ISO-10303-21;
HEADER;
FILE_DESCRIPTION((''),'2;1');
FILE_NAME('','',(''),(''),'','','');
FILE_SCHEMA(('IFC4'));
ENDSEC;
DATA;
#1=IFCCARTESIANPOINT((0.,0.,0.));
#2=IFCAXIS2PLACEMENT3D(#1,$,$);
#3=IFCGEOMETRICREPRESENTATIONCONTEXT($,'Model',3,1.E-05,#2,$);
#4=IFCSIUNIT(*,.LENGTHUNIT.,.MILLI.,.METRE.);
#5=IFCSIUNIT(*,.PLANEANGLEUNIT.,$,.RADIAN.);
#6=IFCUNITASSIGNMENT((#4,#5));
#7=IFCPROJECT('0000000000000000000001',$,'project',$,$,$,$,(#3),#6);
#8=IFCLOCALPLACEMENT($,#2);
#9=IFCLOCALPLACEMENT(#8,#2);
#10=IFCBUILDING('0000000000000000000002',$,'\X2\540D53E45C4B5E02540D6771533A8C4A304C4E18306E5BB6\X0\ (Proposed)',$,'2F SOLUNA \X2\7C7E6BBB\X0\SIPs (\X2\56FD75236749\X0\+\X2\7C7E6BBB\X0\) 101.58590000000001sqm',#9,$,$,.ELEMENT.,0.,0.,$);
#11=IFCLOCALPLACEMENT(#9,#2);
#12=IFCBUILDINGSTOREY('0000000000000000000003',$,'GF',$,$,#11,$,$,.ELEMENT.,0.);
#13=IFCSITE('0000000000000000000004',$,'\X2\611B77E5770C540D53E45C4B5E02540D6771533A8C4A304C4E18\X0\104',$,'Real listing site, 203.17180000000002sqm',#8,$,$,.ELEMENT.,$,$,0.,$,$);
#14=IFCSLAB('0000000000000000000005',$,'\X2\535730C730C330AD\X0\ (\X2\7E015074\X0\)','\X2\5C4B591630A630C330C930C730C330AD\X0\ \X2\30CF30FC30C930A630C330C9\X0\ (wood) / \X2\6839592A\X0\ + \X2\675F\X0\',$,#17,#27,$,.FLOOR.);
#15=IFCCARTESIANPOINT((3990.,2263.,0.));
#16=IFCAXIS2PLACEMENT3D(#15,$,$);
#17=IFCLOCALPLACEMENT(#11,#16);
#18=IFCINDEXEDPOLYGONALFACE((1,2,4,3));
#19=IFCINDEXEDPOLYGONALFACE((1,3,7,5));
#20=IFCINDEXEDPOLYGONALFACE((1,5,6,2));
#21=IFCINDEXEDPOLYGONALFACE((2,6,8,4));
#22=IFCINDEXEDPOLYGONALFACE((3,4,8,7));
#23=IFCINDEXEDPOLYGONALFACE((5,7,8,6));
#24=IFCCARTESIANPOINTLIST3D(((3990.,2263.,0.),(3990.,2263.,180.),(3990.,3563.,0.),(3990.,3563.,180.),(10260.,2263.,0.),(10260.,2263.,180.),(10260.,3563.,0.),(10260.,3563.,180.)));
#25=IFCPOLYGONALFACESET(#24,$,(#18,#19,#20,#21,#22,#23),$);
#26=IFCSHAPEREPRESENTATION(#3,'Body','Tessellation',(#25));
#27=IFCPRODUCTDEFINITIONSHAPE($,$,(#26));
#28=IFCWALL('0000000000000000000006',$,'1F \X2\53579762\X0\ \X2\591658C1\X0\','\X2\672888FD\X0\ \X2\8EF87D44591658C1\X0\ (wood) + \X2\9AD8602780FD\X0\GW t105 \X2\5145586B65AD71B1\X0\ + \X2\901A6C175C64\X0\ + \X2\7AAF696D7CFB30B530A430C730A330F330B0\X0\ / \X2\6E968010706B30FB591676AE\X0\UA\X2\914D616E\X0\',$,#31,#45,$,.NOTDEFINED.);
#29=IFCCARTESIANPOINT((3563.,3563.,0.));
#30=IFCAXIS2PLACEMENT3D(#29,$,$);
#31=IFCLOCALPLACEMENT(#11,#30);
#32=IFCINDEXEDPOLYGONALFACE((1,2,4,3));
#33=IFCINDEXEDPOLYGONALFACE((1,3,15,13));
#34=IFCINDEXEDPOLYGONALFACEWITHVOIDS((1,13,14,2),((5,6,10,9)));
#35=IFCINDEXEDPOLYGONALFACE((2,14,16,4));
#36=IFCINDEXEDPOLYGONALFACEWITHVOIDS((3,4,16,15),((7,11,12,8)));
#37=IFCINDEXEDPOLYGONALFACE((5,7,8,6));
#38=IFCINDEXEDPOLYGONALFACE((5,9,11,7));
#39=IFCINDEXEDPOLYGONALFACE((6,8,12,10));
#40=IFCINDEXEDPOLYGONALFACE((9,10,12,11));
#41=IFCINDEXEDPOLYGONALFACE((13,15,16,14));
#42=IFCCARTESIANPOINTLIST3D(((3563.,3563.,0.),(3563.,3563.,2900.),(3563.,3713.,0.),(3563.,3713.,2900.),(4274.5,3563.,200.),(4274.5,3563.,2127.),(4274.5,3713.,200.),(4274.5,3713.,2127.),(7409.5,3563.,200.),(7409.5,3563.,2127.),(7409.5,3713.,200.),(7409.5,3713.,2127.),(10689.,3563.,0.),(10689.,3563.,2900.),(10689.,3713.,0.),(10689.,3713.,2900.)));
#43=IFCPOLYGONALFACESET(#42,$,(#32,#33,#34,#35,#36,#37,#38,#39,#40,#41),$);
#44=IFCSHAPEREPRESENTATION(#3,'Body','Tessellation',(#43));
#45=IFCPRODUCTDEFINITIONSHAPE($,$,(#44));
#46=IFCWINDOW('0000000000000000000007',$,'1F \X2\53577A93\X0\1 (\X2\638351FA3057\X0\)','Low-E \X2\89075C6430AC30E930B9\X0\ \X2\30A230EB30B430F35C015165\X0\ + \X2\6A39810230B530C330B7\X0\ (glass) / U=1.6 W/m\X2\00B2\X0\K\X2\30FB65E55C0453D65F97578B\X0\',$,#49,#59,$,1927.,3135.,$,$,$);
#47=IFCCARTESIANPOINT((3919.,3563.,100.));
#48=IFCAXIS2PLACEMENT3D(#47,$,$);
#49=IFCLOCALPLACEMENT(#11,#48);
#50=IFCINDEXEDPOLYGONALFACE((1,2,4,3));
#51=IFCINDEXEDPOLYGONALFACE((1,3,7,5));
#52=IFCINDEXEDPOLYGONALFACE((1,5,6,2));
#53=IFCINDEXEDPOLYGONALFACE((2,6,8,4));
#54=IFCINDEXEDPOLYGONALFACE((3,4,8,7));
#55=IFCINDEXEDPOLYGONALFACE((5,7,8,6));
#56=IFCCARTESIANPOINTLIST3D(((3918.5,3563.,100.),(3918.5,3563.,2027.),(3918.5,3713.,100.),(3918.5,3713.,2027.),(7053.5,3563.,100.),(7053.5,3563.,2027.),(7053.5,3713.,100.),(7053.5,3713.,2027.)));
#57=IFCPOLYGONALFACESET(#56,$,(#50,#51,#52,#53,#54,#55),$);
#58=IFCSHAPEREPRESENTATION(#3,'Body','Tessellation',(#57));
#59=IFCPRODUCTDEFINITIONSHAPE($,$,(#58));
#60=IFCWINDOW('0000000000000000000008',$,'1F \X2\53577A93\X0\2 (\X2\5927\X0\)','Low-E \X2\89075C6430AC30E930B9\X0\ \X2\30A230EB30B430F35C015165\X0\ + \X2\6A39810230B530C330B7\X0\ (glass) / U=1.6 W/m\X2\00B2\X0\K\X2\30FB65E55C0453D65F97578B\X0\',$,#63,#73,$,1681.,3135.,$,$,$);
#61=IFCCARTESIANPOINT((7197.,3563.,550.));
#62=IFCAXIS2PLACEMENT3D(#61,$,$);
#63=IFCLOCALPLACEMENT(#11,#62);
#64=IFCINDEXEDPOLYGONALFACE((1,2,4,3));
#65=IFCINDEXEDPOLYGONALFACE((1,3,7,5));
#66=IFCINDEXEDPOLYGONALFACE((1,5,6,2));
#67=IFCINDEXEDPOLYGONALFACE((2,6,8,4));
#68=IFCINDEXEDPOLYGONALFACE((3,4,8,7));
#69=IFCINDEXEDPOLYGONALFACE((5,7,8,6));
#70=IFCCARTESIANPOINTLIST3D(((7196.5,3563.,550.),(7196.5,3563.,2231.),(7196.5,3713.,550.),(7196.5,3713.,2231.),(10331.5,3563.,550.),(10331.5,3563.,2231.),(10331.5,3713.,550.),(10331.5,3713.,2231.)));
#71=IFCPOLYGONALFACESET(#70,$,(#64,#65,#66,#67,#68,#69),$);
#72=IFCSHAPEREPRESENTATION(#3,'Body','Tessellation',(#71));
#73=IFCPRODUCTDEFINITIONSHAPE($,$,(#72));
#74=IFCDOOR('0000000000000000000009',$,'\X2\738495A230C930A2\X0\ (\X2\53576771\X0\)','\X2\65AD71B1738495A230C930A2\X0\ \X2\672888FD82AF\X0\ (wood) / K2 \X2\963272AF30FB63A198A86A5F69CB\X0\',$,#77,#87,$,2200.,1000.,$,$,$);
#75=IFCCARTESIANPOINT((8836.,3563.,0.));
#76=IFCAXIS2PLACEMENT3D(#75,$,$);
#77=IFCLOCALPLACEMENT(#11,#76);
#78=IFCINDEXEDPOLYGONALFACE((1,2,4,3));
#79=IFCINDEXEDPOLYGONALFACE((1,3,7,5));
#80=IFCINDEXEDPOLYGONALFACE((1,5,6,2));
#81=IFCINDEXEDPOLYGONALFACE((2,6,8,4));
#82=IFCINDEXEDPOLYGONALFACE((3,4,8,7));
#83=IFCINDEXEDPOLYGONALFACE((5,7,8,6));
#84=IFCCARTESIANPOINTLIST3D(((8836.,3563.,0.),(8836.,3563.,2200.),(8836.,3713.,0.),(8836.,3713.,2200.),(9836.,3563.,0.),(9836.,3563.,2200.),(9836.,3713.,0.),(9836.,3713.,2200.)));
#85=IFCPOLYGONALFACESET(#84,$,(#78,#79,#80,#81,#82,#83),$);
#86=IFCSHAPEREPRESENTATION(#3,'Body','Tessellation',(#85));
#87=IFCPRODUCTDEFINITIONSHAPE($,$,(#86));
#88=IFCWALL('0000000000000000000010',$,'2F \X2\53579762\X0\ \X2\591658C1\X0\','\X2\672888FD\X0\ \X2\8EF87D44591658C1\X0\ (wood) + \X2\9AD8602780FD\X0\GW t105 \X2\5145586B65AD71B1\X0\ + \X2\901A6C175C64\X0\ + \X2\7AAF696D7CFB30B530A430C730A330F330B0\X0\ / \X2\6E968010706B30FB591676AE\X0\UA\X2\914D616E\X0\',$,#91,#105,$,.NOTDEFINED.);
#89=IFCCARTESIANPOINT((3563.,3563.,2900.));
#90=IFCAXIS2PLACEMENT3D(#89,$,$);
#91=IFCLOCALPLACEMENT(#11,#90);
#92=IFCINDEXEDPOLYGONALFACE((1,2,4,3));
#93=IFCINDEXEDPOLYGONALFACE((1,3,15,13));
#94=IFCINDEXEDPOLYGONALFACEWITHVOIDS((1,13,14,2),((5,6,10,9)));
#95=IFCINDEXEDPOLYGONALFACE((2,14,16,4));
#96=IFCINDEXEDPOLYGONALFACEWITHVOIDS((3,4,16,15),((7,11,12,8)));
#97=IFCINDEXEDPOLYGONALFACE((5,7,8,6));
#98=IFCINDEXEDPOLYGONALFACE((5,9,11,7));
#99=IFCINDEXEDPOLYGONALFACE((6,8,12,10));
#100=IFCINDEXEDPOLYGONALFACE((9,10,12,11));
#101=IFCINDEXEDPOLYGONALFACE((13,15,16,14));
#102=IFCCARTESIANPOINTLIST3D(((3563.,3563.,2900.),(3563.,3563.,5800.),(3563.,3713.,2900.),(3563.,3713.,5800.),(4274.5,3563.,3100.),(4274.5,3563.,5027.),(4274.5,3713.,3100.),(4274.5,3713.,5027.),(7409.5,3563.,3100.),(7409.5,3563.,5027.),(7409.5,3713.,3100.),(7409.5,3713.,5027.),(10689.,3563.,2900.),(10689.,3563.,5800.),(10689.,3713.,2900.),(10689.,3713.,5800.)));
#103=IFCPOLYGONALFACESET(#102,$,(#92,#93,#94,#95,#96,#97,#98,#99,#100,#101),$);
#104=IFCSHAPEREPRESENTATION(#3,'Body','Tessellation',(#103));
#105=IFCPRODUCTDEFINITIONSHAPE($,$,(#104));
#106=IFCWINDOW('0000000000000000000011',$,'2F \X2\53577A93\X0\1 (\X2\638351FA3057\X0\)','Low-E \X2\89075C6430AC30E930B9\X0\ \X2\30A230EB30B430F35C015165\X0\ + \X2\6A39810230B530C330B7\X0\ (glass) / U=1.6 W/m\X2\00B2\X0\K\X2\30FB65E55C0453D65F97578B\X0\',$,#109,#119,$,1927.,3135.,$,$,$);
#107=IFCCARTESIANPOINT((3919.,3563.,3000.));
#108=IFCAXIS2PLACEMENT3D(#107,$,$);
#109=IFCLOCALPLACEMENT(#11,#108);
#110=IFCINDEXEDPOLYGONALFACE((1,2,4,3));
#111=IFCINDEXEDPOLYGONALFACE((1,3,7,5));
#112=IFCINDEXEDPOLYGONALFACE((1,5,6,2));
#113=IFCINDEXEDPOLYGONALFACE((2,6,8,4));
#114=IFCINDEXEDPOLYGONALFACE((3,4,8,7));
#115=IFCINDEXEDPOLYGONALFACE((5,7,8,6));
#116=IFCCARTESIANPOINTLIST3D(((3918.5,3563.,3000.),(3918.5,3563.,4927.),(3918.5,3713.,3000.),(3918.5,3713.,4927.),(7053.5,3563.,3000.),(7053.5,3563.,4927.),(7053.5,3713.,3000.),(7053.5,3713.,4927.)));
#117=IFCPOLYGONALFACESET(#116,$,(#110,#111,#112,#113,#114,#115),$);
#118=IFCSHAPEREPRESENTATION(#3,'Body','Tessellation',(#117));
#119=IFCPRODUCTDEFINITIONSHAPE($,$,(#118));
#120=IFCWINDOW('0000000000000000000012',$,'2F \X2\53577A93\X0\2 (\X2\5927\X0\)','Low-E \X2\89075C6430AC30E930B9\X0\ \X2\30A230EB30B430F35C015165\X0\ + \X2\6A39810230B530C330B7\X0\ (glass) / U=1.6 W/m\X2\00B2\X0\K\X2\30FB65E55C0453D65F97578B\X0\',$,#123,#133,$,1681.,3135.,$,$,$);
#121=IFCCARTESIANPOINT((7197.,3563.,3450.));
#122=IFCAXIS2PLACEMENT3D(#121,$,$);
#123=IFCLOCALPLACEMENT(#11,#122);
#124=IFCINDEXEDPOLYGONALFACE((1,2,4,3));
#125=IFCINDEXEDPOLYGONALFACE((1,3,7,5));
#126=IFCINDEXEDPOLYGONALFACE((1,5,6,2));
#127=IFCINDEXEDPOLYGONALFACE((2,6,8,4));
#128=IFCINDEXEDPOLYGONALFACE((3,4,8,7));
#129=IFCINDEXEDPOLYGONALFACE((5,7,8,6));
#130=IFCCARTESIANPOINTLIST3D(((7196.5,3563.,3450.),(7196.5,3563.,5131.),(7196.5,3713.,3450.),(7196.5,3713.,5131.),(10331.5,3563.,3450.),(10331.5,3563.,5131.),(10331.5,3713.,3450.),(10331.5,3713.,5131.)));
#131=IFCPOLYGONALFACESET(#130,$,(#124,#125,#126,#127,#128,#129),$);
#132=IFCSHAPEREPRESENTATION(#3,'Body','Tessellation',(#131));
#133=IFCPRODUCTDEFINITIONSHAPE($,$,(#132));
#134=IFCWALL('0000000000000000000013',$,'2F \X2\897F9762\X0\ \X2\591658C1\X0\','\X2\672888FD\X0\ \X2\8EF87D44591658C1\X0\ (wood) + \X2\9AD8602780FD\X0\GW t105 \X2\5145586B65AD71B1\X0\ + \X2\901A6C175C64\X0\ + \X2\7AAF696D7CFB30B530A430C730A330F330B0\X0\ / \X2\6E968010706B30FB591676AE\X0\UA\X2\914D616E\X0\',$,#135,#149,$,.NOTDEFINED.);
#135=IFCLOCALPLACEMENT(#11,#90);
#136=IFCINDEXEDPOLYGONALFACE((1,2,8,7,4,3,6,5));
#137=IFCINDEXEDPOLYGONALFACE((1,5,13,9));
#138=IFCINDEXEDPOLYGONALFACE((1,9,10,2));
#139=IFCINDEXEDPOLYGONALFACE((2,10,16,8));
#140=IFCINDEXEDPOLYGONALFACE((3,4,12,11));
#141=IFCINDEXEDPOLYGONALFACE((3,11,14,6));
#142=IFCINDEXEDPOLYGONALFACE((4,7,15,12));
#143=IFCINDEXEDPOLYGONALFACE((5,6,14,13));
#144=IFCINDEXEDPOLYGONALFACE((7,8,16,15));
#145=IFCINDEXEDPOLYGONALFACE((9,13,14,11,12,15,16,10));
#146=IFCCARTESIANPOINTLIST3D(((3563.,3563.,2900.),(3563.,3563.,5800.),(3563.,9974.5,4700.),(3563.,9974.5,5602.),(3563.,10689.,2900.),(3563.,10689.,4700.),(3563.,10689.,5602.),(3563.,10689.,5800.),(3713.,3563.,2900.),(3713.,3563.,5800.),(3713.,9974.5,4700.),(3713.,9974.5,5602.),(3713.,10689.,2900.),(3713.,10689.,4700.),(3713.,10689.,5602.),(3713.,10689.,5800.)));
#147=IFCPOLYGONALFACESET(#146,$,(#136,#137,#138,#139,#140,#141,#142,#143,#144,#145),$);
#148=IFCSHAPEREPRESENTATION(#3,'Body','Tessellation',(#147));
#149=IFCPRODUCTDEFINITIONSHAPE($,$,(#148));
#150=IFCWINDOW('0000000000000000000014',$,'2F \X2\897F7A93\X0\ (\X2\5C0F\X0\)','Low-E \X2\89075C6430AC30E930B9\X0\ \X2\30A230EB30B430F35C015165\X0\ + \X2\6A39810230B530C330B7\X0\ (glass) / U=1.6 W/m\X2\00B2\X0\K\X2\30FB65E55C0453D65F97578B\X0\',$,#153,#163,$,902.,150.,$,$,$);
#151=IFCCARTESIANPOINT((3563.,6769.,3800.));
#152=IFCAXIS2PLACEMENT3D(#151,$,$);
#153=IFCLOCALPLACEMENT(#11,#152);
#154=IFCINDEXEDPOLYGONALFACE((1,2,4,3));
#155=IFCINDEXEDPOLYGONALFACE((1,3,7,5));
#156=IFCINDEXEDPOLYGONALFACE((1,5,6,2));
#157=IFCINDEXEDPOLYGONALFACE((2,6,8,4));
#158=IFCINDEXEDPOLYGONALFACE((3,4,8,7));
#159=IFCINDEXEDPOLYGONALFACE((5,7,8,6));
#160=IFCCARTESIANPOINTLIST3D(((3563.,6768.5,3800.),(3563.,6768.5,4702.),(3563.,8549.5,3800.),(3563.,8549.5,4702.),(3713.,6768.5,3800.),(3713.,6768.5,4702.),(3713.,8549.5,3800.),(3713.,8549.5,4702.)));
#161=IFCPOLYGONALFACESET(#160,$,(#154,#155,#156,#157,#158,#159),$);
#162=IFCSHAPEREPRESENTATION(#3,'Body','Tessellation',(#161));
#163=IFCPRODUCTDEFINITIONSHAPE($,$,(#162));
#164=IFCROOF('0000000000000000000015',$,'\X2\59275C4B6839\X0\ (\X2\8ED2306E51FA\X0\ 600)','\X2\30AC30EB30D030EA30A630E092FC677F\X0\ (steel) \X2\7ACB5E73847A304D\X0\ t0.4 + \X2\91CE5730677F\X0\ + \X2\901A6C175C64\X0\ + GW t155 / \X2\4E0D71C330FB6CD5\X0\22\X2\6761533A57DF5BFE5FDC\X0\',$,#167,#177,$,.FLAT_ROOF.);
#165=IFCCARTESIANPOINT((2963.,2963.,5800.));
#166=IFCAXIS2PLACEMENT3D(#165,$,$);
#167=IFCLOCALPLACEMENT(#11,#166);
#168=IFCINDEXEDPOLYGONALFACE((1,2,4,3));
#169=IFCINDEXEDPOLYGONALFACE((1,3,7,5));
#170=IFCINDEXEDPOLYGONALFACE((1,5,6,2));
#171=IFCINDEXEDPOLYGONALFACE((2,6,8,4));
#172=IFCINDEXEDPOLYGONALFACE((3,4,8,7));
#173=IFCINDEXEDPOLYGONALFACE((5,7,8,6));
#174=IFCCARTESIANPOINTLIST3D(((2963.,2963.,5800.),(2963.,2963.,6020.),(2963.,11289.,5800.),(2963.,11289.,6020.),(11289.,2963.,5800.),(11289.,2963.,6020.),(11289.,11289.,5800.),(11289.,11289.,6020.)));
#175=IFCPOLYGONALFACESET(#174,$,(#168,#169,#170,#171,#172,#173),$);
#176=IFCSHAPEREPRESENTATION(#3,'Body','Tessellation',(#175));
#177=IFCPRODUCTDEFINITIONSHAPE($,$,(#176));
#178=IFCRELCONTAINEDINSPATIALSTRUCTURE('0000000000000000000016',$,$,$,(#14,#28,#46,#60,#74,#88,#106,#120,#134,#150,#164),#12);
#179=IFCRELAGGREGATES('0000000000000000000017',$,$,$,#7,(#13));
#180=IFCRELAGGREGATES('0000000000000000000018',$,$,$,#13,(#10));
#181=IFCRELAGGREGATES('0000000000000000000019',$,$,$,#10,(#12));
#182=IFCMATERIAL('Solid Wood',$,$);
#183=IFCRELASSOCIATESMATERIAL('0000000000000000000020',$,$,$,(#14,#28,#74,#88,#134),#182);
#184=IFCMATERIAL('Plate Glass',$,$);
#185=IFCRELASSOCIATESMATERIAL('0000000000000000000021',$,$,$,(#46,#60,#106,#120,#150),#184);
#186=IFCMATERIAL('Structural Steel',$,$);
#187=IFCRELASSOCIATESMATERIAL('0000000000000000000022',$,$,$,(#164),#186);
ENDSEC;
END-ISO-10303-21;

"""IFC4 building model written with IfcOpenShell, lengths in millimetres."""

from ifc_helpers import new_model, si_unit, frame, frame_2d, origin, place, context, project, spatial, rectangle, extrude, material, element, fill, save


model = new_model("IFC4")

# Units and contexts
model_context = context("Model", 3, precision=1e-05, world=origin())
ifc_project = project(units=[si_unit("LENGTHUNIT", "METRE", prefix="MILLI"), si_unit("PLANEANGLEUNIT", "RADIAN")], contexts=[model_context])

# Site, building, storey
site_placement = place(None, origin())
site = spatial("IfcSite", under=ifc_project, at=site_placement, Name="愛知県名古屋市名東区豊が丘104", ObjectType="Real listing site, 203.17180000000002sqm", CompositionType="ELEMENT", RefElevation=0.0)
building_placement = place(site_placement, origin())
building = spatial("IfcBuilding", under=site, at=building_placement, Name="名古屋市名東区豊が丘の家 (Proposed)", ObjectType="2F SOLUNA 籾殻SIPs (国産杉+籾殻) 101.58590000000001sqm", CompositionType="ELEMENT", ElevationOfRefHeight=0.0, ElevationOfTerrain=0.0)
storey_placement = place(building_placement, origin())
storey = spatial("IfcBuildingStorey", under=building, at=storey_placement, Name="GF", CompositionType="ELEMENT", Elevation=0.0)

# Slab
ifc_material_1 = material(Name="Solid Wood")
slab_1_placement = place(storey_placement, frame((3990.0, 2263.0, 0.0)))
element("IfcSlab", 1, at=slab_1_placement, inside=storey, material=ifc_material_1, Name="南デッキ (縁側)", Description="屋外ウッドデッキ ハードウッド (wood) / 根太 + 束", PredefinedType="FLOOR", context=model_context, shape_type="SweptSolid", body=[
    extrude(rectangle(XDim=6270.0, YDim=1300.0, at=frame_2d((3135.0, 650.0))), frame((3990.0, 2263.0, 0.0)), (0.0, 0.0, 1.0), 180.0),
])

# Wall, openings, windows, door
wall_1_placement = place(storey_placement, frame((3563.0, 3563.0, 0.0)))
wall_1 = element("IfcWall", 2, at=wall_1_placement, inside=storey, material=ifc_material_1, Name="1F 南面 外壁", Description="木製 軸組外壁 (wood) + 高性能GW t105 充填断熱 + 通気層 + 窯業系サイディング / 準耐火・外皮UA配慮", PredefinedType="NOTDEFINED", context=model_context, shape_type="SweptSolid", body=[
    extrude(rectangle(XDim=7126.0, YDim=150.0, at=frame_2d((3563.0, 75.0))), frame((3563.0, 3563.0, 0.0)), (0.0, 0.0, 1.0), 2900.0),
])
opening_1_placement = place(storey_placement, frame((3919.0, 3563.0, 100.0)))
opening_1 = element("IfcOpeningElement", 3, at=opening_1_placement, cuts=wall_1, PredefinedType="NOTDEFINED", context=model_context, shape_type="SweptSolid", body=[
    extrude(rectangle(XDim=3135.0, YDim=150.0, at=frame_2d((1567.0, 75.0))), frame((3919.0, 3563.0, 100.0)), (0.0, 0.0, 1.0), 1927.0),
])
opening_2_placement = place(storey_placement, frame((7197.0, 3563.0, 550.0)))
opening_2 = element("IfcOpeningElement", 4, at=opening_2_placement, cuts=wall_1, PredefinedType="NOTDEFINED", context=model_context, shape_type="SweptSolid", body=[
    extrude(rectangle(XDim=3135.0, YDim=150.0, at=frame_2d((1567.0, 75.0))), frame((7197.0, 3563.0, 550.0)), (0.0, 0.0, 1.0), 1681.0),
])
opening_3_placement = place(storey_placement, frame((8836.0, 3563.0, 0.0)))
opening_3 = element("IfcOpeningElement", 5, at=opening_3_placement, cuts=wall_1, PredefinedType="NOTDEFINED", context=model_context, shape_type="SweptSolid", body=[
    extrude(rectangle(XDim=1000.0, YDim=150.0, at=frame_2d((500.0, 75.0))), frame((8836.0, 3563.0, 0.0)), (0.0, 0.0, 1.0), 2200.0),
])
ifc_material_2 = material(Name="Plate Glass")
window_1_placement = place(storey_placement, frame((3919.0, 3563.0, 100.0)))
window_1 = element("IfcWindow", 6, at=window_1_placement, inside=storey, material=ifc_material_2, Name="1F 南窓1 (掃出し)", Description="Low-E 複層ガラス アルゴン封入 + 樹脂サッシ (glass) / U=1.6 W/m²K・日射取得型", OverallHeight=1927.0, OverallWidth=3135.0, context=model_context, shape_type="SweptSolid", body=[
    extrude(rectangle(XDim=3135.0, YDim=150.0, at=frame_2d((1567.0, 75.0))), frame((3919.0, 3563.0, 100.0)), (0.0, 0.0, 1.0), 1927.0),
])
fill(opening_1, window_1)
window_2_placement = place(storey_placement, frame((7197.0, 3563.0, 550.0)))
window_2 = element("IfcWindow", 7, at=window_2_placement, inside=storey, material=ifc_material_2, Name="1F 南窓2 (大)", Description="Low-E 複層ガラス アルゴン封入 + 樹脂サッシ (glass) / U=1.6 W/m²K・日射取得型", OverallHeight=1681.0, OverallWidth=3135.0, context=model_context, shape_type="SweptSolid", body=[
    extrude(rectangle(XDim=3135.0, YDim=150.0, at=frame_2d((1567.0, 75.0))), frame((7197.0, 3563.0, 550.0)), (0.0, 0.0, 1.0), 1681.0),
])
fill(opening_2, window_2)
door_placement = place(storey_placement, frame((8836.0, 3563.0, 0.0)))
door = element("IfcDoor", 8, at=door_placement, inside=storey, material=ifc_material_1, Name="玄関ドア (南東)", Description="断熱玄関ドア 木製芯 (wood) / K2 防犯・採風機構", OverallHeight=2200.0, OverallWidth=1000.0, context=model_context, shape_type="SweptSolid", body=[
    extrude(rectangle(XDim=1000.0, YDim=150.0, at=frame_2d((500.0, 75.0))), frame((8836.0, 3563.0, 0.0)), (0.0, 0.0, 1.0), 2200.0),
])
fill(opening_3, door)

# Wall, openings, windows
wall_2_placement = place(storey_placement, frame((3563.0, 3563.0, 2900.0)))
wall_2 = element("IfcWall", 9, at=wall_2_placement, inside=storey, material=ifc_material_1, Name="2F 南面 外壁", Description="木製 軸組外壁 (wood) + 高性能GW t105 充填断熱 + 通気層 + 窯業系サイディング / 準耐火・外皮UA配慮", PredefinedType="NOTDEFINED", context=model_context, shape_type="SweptSolid", body=[
    extrude(rectangle(XDim=7126.0, YDim=150.0, at=frame_2d((3563.0, 75.0))), frame((3563.0, 3563.0, 2900.0)), (0.0, 0.0, 1.0), 2900.0),
])
opening_4_placement = place(storey_placement, frame((3919.0, 3563.0, 3000.0)))
opening_4 = element("IfcOpeningElement", 10, at=opening_4_placement, cuts=wall_2, PredefinedType="NOTDEFINED", context=model_context, shape_type="SweptSolid", body=[
    extrude(rectangle(XDim=3135.0, YDim=150.0, at=frame_2d((1567.0, 75.0))), frame((3919.0, 3563.0, 3000.0)), (0.0, 0.0, 1.0), 1927.0),
])
opening_5_placement = place(storey_placement, frame((7197.0, 3563.0, 3450.0)))
opening_5 = element("IfcOpeningElement", 11, at=opening_5_placement, cuts=wall_2, PredefinedType="NOTDEFINED", context=model_context, shape_type="SweptSolid", body=[
    extrude(rectangle(XDim=3135.0, YDim=150.0, at=frame_2d((1567.0, 75.0))), frame((7197.0, 3563.0, 3450.0)), (0.0, 0.0, 1.0), 1681.0),
])
window_3_placement = place(storey_placement, frame((3919.0, 3563.0, 3000.0)))
window_3 = element("IfcWindow", 12, at=window_3_placement, inside=storey, material=ifc_material_2, Name="2F 南窓1 (掃出し)", Description="Low-E 複層ガラス アルゴン封入 + 樹脂サッシ (glass) / U=1.6 W/m²K・日射取得型", OverallHeight=1927.0, OverallWidth=3135.0, context=model_context, shape_type="SweptSolid", body=[
    extrude(rectangle(XDim=3135.0, YDim=150.0, at=frame_2d((1567.0, 75.0))), frame((3919.0, 3563.0, 3000.0)), (0.0, 0.0, 1.0), 1927.0),
])
fill(opening_4, window_3)
window_4_placement = place(storey_placement, frame((7197.0, 3563.0, 3450.0)))
window_4 = element("IfcWindow", 13, at=window_4_placement, inside=storey, material=ifc_material_2, Name="2F 南窓2 (大)", Description="Low-E 複層ガラス アルゴン封入 + 樹脂サッシ (glass) / U=1.6 W/m²K・日射取得型", OverallHeight=1681.0, OverallWidth=3135.0, context=model_context, shape_type="SweptSolid", body=[
    extrude(rectangle(XDim=3135.0, YDim=150.0, at=frame_2d((1567.0, 75.0))), frame((7197.0, 3563.0, 3450.0)), (0.0, 0.0, 1.0), 1681.0),
])
fill(opening_5, window_4)

# Wall, opening, window
wall_3_placement = place(storey_placement, frame((3563.0, 3563.0, 2900.0)))
wall_3 = element("IfcWall", 14, at=wall_3_placement, inside=storey, material=ifc_material_1, Name="2F 西面 外壁", Description="木製 軸組外壁 (wood) + 高性能GW t105 充填断熱 + 通気層 + 窯業系サイディング / 準耐火・外皮UA配慮", PredefinedType="NOTDEFINED", context=model_context, shape_type="SweptSolid", body=[
    extrude(rectangle(XDim=150.0, YDim=7126.0, at=frame_2d((75.0, 3563.0))), frame((3563.0, 3563.0, 2900.0)), (0.0, 0.0, 1.0), 2900.0),
])
opening_6_placement = place(storey_placement, frame((3563.0, 6769.0, 3800.0)))
opening_6 = element("IfcOpeningElement", 15, at=opening_6_placement, cuts=wall_3, PredefinedType="NOTDEFINED", context=model_context, shape_type="SweptSolid", body=[
    extrude(rectangle(XDim=150.0, YDim=1781.0, at=frame_2d((75.0, 890.0))), frame((3563.0, 6769.0, 3800.0)), (0.0, 0.0, 1.0), 902.0),
])
window_5_placement = place(storey_placement, frame((3563.0, 6769.0, 3800.0)))
window_5 = element("IfcWindow", 16, at=window_5_placement, inside=storey, material=ifc_material_2, Name="2F 西窓 (小)", Description="Low-E 複層ガラス アルゴン封入 + 樹脂サッシ (glass) / U=1.6 W/m²K・日射取得型", OverallHeight=902.0, OverallWidth=150.0, context=model_context, shape_type="SweptSolid", body=[
    extrude(rectangle(XDim=150.0, YDim=1781.0, at=frame_2d((75.0, 890.0))), frame((3563.0, 6769.0, 3800.0)), (0.0, 0.0, 1.0), 902.0),
])
fill(opening_6, window_5)

# Roof
ifc_material_3 = material(Name="Structural Steel")
roof_placement = place(storey_placement, frame((2963.0, 2963.0, 5800.0)))
element("IfcRoof", 17, at=roof_placement, inside=storey, material=ifc_material_3, Name="大屋根 (軒の出 600)", Description="ガルバリウム鋼板 (steel) 立平葺き t0.4 + 野地板 + 通気層 + GW t155 / 不燃・法22条区域対応", PredefinedType="FLAT_ROOF", context=model_context, shape_type="SweptSolid", body=[
    extrude(rectangle(XDim=8326.0, YDim=8326.0, at=frame_2d((4163.0, 4163.0))), frame((2963.0, 2963.0, 5800.0)), (0.0, 0.0, 1.0), 220.0),
])

save(model, "model.ifc")
